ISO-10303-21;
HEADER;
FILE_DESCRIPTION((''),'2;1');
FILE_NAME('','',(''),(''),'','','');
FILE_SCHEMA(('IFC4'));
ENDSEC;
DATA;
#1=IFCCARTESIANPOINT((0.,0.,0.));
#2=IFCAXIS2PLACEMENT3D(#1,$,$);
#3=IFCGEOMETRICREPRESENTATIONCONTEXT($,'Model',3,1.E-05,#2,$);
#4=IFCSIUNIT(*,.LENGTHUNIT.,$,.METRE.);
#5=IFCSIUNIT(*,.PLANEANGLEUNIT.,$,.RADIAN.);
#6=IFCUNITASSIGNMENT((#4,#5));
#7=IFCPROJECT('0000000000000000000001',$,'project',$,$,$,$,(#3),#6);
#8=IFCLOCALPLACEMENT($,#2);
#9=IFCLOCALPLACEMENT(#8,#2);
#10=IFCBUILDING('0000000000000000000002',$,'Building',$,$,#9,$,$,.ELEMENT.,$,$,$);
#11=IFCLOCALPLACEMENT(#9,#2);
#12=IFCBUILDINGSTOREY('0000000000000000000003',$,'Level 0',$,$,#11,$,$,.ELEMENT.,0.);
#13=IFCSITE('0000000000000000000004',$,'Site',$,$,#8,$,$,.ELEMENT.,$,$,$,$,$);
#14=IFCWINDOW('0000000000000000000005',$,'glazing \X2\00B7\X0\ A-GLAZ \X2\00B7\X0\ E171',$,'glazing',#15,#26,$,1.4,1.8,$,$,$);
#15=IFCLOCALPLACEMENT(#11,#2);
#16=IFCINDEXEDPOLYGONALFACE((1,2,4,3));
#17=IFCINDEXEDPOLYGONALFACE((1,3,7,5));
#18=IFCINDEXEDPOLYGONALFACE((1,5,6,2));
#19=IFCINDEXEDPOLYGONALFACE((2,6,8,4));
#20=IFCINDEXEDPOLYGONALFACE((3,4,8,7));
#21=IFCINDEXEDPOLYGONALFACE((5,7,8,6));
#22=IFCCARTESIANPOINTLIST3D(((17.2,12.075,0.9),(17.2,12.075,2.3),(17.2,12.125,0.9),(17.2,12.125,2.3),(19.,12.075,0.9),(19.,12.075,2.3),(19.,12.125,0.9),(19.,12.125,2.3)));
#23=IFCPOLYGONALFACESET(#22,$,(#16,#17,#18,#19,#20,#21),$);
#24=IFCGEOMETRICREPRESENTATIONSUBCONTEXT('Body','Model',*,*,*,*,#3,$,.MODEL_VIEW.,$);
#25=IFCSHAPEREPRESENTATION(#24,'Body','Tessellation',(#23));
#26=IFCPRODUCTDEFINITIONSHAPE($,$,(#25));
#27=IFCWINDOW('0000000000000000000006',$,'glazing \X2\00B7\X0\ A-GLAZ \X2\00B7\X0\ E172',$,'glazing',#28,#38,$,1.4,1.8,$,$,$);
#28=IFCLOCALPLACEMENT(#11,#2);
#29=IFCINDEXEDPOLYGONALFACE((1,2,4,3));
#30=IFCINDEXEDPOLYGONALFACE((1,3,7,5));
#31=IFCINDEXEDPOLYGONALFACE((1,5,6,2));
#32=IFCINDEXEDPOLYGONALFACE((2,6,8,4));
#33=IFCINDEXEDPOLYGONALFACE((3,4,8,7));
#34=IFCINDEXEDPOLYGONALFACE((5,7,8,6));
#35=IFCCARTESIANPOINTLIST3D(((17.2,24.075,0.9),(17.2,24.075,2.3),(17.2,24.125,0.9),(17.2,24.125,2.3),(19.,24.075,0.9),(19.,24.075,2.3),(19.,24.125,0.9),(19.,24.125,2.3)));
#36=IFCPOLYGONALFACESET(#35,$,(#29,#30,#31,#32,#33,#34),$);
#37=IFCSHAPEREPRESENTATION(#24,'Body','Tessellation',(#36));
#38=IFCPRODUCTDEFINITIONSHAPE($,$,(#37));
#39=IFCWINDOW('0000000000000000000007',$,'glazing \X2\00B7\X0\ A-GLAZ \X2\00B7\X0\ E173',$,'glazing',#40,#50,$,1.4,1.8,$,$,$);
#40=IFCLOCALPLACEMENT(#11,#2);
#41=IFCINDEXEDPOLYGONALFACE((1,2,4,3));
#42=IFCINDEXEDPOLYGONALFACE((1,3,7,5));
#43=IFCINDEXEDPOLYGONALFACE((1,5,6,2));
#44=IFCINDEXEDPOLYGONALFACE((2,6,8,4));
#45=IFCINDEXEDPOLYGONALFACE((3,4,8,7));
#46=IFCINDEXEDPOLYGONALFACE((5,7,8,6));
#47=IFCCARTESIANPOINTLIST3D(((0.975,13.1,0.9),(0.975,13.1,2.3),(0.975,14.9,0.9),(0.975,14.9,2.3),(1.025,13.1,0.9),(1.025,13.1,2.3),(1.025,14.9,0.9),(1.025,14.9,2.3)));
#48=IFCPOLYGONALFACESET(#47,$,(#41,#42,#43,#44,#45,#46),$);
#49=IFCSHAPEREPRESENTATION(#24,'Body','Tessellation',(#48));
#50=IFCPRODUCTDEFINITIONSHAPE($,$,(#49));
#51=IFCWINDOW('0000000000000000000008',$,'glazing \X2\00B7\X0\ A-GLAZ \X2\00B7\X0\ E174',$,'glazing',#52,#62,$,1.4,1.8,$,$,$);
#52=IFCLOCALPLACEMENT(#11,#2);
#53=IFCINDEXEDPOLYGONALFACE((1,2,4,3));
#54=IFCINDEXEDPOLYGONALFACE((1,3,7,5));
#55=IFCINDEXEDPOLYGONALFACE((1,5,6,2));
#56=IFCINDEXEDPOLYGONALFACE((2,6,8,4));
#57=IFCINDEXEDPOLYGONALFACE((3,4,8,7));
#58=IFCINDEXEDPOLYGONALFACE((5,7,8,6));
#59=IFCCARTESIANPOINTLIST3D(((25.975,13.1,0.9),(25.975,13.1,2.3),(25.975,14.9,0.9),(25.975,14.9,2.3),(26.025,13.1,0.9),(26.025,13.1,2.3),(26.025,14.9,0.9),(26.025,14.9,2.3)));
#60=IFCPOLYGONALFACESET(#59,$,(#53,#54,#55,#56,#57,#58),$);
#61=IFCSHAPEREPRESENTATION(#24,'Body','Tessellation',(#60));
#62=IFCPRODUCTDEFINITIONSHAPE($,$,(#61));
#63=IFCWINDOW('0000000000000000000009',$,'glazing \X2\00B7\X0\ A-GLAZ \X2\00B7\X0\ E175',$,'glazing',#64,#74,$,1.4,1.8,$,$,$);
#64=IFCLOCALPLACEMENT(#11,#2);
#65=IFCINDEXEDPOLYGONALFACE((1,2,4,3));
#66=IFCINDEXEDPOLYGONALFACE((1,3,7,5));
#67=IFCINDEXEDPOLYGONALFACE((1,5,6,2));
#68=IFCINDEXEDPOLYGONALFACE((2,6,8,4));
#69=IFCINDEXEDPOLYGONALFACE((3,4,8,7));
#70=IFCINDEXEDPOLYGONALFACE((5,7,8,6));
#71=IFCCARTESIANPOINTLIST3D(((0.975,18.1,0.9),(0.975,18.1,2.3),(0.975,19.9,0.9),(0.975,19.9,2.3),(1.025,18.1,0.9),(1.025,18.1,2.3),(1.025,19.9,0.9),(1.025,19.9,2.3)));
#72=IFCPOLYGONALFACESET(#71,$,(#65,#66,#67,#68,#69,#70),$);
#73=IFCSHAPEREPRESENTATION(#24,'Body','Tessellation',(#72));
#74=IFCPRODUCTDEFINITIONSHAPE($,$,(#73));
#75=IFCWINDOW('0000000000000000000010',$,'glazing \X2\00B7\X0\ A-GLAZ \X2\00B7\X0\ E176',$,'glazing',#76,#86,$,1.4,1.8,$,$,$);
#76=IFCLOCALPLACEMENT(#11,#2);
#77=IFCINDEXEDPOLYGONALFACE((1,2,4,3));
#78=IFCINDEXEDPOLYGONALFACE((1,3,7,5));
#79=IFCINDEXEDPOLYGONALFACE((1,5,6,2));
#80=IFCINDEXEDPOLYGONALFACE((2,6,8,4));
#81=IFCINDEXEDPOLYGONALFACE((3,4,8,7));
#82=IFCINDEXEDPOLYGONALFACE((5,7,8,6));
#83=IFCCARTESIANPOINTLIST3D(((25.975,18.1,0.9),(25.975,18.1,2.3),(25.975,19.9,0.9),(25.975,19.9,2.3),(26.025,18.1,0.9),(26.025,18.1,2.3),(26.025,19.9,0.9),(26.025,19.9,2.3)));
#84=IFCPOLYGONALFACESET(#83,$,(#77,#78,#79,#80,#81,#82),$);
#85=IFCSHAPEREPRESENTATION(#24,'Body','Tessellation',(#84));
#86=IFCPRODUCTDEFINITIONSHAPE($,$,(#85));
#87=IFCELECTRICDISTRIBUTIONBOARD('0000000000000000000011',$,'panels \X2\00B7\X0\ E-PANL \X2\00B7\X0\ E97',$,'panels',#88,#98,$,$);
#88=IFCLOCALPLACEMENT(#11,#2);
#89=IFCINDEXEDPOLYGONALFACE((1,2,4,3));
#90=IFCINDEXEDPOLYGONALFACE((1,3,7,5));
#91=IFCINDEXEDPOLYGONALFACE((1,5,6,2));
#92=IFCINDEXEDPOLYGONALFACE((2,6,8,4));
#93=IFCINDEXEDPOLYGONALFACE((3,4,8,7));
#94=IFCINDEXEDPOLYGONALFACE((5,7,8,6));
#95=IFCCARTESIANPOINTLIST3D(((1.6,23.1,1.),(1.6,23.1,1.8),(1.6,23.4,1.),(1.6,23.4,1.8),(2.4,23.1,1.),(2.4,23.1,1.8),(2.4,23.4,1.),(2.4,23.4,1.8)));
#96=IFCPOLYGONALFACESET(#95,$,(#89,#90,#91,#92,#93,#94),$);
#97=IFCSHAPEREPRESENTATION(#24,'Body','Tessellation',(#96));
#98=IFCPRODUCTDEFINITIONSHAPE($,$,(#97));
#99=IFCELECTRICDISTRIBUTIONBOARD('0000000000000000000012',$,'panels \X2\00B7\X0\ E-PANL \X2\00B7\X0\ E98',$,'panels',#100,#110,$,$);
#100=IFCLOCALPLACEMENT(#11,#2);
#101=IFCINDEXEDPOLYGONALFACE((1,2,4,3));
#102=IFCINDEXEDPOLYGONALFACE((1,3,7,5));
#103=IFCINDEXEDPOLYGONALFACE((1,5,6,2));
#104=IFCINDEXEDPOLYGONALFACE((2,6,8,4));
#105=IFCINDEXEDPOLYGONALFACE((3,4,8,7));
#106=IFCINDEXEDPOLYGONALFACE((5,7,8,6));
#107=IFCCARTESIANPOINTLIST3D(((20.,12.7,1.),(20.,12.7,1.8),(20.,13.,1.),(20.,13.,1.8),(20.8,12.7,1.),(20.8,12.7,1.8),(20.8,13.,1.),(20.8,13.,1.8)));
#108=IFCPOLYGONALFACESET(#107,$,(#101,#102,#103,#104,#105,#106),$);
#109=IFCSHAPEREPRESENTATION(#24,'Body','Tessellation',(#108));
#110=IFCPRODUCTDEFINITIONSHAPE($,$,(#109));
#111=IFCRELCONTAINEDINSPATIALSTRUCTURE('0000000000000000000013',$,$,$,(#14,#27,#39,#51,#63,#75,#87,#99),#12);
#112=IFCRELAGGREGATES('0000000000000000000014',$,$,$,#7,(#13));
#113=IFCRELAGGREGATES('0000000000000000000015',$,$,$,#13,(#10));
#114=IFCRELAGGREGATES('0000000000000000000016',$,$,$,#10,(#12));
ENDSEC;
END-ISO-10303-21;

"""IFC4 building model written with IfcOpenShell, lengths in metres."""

from ifc_helpers import new_model, si_unit, frame, origin, place, context, subcontext, project, spatial, polyline, outline, extrude, element, save


model = new_model("IFC4")

# Units and contexts
model_context = context("Model", 3, precision=1e-05, world=origin())
body_context = subcontext(model_context, "Body", "Model", "MODEL_VIEW")
ifc_project = project(units=[si_unit("LENGTHUNIT", "METRE"), si_unit("PLANEANGLEUNIT", "RADIAN")], contexts=[model_context])

# Site, building, storey
site_placement = place(None, origin())
site = spatial("IfcSite", under=ifc_project, at=site_placement, Name="Site", CompositionType="ELEMENT")
building_placement = place(site_placement, origin())
building = spatial("IfcBuilding", under=site, at=building_placement, Name="Building", CompositionType="ELEMENT")
storey_placement = place(building_placement, origin())
storey = spatial("IfcBuildingStorey", under=building, at=storey_placement, Name="Level 0", CompositionType="ELEMENT", Elevation=0.0)

# Windows
window_1_placement = place(storey_placement, frame((0.0, 0.0, 0.9)))
element("IfcWindow", 1, at=window_1_placement, inside=storey, Name="glazing · A-GLAZ · E171", ObjectType="glazing", OverallHeight=1.4, OverallWidth=1.8, context=body_context, shape_type="SweptSolid", body=[
    extrude(outline(polyline([(17.2, 12.075), (19.0, 12.075), (19.0, 12.125), (17.2, 12.125), (17.2, 12.075)])), origin(), (0.0, 0.0, 1.0), 1.4),
])
window_2_placement = place(storey_placement, frame((0.0, 0.0, 0.9)))
element("IfcWindow", 2, at=window_2_placement, inside=storey, Name="glazing · A-GLAZ · E172", ObjectType="glazing", OverallHeight=1.4, OverallWidth=1.8, context=body_context, shape_type="SweptSolid", body=[
    extrude(outline(polyline([(19.0, 24.125), (17.2, 24.125), (17.2, 24.075), (19.0, 24.075), (19.0, 24.125)])), origin(), (0.0, 0.0, 1.0), 1.4),
])
window_3_placement = place(storey_placement, frame((0.0, 0.0, 0.9)))
element("IfcWindow", 3, at=window_3_placement, inside=storey, Name="glazing · A-GLAZ · E173", ObjectType="glazing", OverallHeight=1.4, OverallWidth=1.8, context=body_context, shape_type="SweptSolid", body=[
    extrude(outline(polyline([(0.975, 14.9), (0.975, 13.1), (1.025, 13.1), (1.025, 14.9), (0.975, 14.9)])), origin(), (0.0, 0.0, 1.0), 1.4),
])
window_4_placement = place(storey_placement, frame((0.0, 0.0, 0.9)))
element("IfcWindow", 4, at=window_4_placement, inside=storey, Name="glazing · A-GLAZ · E174", ObjectType="glazing", OverallHeight=1.4, OverallWidth=1.8, context=body_context, shape_type="SweptSolid", body=[
    extrude(outline(polyline([(26.025, 13.1), (26.025, 14.9), (25.975, 14.9), (25.975, 13.1), (26.025, 13.1)])), origin(), (0.0, 0.0, 1.0), 1.4),
])
window_5_placement = place(storey_placement, frame((0.0, 0.0, 0.9)))
element("IfcWindow", 5, at=window_5_placement, inside=storey, Name="glazing · A-GLAZ · E175", ObjectType="glazing", OverallHeight=1.4, OverallWidth=1.8, context=body_context, shape_type="SweptSolid", body=[
    extrude(outline(polyline([(0.975, 19.9), (0.975, 18.1), (1.025, 18.1), (1.025, 19.9), (0.975, 19.9)])), origin(), (0.0, 0.0, 1.0), 1.4),
])
window_6_placement = place(storey_placement, frame((0.0, 0.0, 0.9)))
element("IfcWindow", 6, at=window_6_placement, inside=storey, Name="glazing · A-GLAZ · E176", ObjectType="glazing", OverallHeight=1.4, OverallWidth=1.8, context=body_context, shape_type="SweptSolid", body=[
    extrude(outline(polyline([(26.025, 18.1), (26.025, 19.9), (25.975, 19.9), (25.975, 18.1), (26.025, 18.1)])), origin(), (0.0, 0.0, 1.0), 1.4),
])

# Electric distribution boards
electric_distribution_board_1_placement = place(storey_placement, frame((0.0, 0.0, 1.0)))
element("IfcElectricDistributionBoard", 7, at=electric_distribution_board_1_placement, inside=storey, Name="panels · E-PANL · E97", ObjectType="panels", context=body_context, shape_type="SweptSolid", body=[
    extrude(outline(polyline([(1.6, 23.1), (2.4, 23.1), (2.4, 23.4), (1.6, 23.4), (1.6, 23.1)])), origin(), (0.0, 0.0, 1.0), 0.8),
])
electric_distribution_board_2_placement = place(storey_placement, frame((0.0, 0.0, 1.0)))
element("IfcElectricDistributionBoard", 8, at=electric_distribution_board_2_placement, inside=storey, Name="panels · E-PANL · E98", ObjectType="panels", context=body_context, shape_type="SweptSolid", body=[
    extrude(outline(polyline([(20.0, 12.7), (20.8, 12.7), (20.8, 13.0), (20.0, 13.0), (20.0, 12.7)])), origin(), (0.0, 0.0, 1.0), 0.8),
])

save(model, "model.ifc")
